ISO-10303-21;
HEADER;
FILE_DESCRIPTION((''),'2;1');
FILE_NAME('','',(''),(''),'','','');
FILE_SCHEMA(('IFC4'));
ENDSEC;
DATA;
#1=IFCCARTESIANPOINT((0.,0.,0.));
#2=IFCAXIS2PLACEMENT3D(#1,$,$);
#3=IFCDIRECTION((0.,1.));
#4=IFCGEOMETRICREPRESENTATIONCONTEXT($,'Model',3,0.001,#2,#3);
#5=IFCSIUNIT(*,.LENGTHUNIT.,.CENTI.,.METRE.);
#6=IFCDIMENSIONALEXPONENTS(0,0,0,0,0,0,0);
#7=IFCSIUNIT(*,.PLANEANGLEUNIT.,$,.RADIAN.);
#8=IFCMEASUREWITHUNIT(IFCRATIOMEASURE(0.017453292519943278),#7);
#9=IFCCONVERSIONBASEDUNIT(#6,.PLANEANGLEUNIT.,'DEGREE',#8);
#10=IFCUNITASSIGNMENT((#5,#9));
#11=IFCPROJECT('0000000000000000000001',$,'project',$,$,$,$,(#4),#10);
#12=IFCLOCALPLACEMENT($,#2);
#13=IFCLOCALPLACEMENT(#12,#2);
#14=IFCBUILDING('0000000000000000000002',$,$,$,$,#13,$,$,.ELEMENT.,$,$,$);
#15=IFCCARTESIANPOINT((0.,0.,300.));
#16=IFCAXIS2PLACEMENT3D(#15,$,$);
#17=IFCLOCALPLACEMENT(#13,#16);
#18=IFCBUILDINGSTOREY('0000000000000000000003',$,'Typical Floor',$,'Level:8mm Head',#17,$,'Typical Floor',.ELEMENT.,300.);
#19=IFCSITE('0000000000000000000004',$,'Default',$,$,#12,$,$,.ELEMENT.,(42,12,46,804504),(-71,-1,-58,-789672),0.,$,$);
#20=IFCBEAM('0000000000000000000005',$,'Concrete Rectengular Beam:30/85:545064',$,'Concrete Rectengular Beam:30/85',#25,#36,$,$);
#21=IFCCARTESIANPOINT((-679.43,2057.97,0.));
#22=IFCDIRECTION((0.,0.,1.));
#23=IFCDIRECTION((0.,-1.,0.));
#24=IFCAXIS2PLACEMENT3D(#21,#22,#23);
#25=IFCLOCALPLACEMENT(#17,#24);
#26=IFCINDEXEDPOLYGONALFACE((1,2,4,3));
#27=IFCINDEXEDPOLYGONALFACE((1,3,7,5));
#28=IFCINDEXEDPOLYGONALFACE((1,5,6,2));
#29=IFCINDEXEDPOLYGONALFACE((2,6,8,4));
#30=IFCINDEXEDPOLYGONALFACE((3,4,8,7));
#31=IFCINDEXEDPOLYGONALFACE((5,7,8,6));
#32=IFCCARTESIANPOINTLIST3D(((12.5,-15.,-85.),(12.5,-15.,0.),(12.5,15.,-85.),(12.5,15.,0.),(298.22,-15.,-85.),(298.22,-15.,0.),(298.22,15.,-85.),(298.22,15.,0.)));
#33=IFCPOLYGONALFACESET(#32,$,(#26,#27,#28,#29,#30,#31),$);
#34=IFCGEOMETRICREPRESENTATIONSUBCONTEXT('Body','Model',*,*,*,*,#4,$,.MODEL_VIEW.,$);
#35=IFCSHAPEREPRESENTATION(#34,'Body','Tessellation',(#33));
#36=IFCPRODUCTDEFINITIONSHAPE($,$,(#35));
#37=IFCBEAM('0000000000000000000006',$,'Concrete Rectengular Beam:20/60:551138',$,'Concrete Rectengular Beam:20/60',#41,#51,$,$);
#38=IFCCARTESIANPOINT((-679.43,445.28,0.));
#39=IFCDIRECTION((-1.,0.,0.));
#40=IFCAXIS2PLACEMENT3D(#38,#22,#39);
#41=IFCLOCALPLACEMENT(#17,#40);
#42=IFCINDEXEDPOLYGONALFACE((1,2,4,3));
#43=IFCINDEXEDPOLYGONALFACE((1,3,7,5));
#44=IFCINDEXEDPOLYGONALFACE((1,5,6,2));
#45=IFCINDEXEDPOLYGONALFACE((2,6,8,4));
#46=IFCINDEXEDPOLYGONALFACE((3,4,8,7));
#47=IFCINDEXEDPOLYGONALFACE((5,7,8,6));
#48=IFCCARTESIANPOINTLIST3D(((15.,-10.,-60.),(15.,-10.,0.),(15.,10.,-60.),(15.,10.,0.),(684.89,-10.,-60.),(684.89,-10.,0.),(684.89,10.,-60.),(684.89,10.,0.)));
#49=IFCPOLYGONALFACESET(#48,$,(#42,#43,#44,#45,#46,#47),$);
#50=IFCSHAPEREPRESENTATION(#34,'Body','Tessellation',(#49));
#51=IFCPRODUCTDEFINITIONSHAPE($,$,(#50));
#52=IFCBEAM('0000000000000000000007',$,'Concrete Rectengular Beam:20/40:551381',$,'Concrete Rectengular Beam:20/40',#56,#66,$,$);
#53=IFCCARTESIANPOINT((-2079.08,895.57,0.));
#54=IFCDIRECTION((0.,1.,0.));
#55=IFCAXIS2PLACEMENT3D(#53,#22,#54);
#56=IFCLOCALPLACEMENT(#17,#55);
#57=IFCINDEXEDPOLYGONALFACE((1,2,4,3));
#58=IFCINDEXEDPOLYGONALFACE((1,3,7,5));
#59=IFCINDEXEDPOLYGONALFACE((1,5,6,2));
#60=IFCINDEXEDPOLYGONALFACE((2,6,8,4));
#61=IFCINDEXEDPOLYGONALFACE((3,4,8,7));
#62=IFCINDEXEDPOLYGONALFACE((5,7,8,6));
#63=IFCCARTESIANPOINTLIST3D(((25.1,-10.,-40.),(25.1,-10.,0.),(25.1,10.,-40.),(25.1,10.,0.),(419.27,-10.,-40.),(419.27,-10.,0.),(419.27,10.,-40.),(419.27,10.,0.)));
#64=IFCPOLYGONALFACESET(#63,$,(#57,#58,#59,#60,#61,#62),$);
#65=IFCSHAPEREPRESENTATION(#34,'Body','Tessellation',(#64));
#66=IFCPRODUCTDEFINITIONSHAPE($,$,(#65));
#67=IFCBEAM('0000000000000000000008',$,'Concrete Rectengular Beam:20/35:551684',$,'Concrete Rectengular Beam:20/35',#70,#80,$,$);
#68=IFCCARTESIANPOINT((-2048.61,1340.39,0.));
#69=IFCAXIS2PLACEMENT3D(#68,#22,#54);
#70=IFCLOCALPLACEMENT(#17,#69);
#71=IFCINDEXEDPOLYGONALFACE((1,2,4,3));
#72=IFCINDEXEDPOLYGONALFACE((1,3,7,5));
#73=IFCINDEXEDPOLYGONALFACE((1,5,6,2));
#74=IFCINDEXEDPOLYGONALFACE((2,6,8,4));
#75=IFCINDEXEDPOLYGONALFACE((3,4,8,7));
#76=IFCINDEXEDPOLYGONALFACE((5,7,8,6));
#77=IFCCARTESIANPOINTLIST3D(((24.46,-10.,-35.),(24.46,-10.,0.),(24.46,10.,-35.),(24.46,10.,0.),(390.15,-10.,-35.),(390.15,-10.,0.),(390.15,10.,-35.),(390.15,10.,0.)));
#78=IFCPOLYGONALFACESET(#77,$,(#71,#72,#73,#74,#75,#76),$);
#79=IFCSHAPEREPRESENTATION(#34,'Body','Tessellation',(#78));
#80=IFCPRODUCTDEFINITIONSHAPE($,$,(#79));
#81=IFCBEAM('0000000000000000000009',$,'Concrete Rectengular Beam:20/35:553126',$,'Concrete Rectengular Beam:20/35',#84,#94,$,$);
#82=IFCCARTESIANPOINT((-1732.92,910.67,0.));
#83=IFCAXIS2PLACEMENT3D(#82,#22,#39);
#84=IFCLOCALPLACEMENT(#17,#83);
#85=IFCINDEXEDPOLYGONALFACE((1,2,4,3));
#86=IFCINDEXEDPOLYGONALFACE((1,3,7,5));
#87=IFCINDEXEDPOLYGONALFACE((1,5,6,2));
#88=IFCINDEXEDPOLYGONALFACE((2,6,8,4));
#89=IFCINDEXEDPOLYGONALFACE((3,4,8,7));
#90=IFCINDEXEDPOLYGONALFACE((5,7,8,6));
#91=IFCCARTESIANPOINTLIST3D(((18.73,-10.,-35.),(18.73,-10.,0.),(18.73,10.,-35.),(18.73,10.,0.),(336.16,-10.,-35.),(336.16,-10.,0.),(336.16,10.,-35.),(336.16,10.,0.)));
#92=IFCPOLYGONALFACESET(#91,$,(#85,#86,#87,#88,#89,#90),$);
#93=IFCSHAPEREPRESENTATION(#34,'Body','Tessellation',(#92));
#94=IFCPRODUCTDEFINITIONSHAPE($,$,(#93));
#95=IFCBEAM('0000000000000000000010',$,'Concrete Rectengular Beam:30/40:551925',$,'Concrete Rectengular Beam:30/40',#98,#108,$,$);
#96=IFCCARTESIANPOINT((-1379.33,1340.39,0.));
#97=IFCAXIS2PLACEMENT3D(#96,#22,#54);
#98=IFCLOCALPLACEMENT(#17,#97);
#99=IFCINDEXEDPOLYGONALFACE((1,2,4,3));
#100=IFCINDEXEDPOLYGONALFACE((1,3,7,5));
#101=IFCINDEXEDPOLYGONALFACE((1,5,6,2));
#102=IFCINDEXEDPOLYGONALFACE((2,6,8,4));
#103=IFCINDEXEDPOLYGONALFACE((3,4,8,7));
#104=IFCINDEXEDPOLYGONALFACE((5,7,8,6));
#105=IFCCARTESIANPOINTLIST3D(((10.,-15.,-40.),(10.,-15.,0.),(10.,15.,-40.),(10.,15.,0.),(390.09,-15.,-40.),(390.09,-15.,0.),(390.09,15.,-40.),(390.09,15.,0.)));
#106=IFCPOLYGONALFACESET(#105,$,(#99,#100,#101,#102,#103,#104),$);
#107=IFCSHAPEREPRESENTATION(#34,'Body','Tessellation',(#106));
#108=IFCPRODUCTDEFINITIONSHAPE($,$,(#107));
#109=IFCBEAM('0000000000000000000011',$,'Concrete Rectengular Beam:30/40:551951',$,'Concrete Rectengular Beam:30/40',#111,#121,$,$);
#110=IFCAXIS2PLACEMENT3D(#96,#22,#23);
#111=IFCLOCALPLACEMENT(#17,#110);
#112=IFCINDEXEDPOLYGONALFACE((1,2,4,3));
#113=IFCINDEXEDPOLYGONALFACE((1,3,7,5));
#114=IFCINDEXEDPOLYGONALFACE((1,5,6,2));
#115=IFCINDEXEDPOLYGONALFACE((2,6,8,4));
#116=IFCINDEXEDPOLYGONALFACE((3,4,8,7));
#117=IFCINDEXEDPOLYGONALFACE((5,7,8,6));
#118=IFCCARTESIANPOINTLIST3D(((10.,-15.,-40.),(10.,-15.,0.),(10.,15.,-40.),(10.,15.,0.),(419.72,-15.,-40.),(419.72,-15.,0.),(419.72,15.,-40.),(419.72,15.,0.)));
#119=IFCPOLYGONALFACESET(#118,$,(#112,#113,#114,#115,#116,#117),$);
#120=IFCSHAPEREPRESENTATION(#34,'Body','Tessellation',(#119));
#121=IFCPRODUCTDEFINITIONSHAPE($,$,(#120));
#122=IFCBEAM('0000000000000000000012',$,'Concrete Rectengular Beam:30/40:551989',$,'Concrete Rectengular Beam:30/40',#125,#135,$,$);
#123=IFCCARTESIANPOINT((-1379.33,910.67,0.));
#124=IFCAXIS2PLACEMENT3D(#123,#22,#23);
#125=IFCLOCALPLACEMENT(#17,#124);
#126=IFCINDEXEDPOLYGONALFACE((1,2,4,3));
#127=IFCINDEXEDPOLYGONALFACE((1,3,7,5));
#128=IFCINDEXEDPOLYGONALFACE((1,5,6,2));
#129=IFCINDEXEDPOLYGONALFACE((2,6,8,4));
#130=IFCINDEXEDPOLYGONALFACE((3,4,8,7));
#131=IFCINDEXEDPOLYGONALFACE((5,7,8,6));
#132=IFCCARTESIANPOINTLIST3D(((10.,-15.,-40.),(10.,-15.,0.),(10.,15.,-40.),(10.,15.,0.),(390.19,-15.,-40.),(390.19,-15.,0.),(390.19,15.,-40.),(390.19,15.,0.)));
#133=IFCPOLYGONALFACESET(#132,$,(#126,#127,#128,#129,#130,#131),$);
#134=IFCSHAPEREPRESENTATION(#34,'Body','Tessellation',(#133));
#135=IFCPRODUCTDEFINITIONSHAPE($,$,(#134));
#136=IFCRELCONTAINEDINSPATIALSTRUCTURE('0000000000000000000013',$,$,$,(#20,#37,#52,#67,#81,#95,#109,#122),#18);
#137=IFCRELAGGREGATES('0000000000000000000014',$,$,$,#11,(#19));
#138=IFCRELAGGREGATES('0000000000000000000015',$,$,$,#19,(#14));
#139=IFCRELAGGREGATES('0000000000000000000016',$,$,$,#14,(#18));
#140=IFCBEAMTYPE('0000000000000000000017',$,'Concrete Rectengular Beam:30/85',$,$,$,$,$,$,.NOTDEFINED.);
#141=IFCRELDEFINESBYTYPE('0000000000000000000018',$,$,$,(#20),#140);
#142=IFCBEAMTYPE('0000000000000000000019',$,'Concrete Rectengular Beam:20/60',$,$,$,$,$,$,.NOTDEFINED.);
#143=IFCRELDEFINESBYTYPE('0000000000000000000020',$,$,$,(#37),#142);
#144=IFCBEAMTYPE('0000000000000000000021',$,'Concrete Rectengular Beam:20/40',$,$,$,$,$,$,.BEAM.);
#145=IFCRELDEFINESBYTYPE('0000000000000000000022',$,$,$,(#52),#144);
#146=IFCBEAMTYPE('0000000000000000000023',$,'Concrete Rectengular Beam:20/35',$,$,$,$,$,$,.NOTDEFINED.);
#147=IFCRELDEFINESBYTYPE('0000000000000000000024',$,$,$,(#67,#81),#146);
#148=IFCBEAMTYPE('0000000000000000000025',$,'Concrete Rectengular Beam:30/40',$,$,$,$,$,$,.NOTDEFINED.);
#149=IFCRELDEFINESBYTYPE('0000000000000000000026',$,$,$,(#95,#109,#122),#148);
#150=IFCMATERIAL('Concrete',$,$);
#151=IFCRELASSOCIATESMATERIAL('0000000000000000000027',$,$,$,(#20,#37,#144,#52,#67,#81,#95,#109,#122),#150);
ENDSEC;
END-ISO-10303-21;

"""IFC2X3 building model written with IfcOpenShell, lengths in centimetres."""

from ifc_helpers import new_model, entity, si_unit, converted_unit, direction, frame, frame_2d, origin, place, context, subcontext, project, spatial, rectangle, extrude, material, type_object, element, save


model = new_model("IFC2X3")

# Units and contexts
model_context = context("Model", 3, precision=0.001, world=origin(), true_north=direction((0.0, 1.0)))
body_context = subcontext(model_context, "Body", "Model", "MODEL_VIEW")
ifc_project = project(units=[si_unit("LENGTHUNIT", "METRE", prefix="CENTI"), converted_unit("PLANEANGLEUNIT", "DEGREE", entity("IfcRatioMeasure", 0.017453292519943278), si_unit("PLANEANGLEUNIT", "RADIAN"), dimensions=[0, 0, 0, 0, 0, 0, 0])], contexts=[model_context])

# Site, building, storey
site_placement = place(None, origin())
site = spatial("IfcSite", under=ifc_project, at=site_placement, Name="Default", CompositionType="ELEMENT", RefLatitude=(42, 12, 46, 804504), RefLongitude=(-71, -1, -58, -789672), RefElevation=0.0)
building_placement = place(site_placement, origin())
building = spatial("IfcBuilding", under=site, at=building_placement, CompositionType="ELEMENT")
storey_placement = place(building_placement, frame((0.0, 0.0, 300.0)))
storey = spatial("IfcBuildingStorey", under=building, at=storey_placement, Name="Typical Floor", ObjectType="Level:8mm Head", LongName="Typical Floor", CompositionType="ELEMENT", Elevation=300.0)

# Beams
ifc_material = material(Name="Concrete")
beam_type_1 = type_object("IfcBeamType", Name="Concrete Rectengular Beam:30/85", PredefinedType="NOTDEFINED")
beam_1_placement = place(storey_placement, frame((-679.43, 2057.97, 0.0), z_axis=(0.0, 0.0, 1.0), x_axis=(0.0, -1.0, 0.0)))
element("IfcBeam", 1, at=beam_1_placement, inside=storey, type_object=beam_type_1, material=ifc_material, Name="Concrete Rectengular Beam:30/85:545064", ObjectType="Concrete Rectengular Beam:30/85", context=body_context, shape_type="SweptSolid", body=[
    extrude(rectangle(XDim=85.0, YDim=30.0, at=frame_2d((0.0, 0.0), x_axis=(1.0, 0.0))), frame((12.5, 0.0, -42.5), z_axis=(1.0, 0.0, 0.0), x_axis=(0.0, 0.0, -1.0)), (0.0, 0.0, 1.0), 285.72),
])
beam_type_2 = type_object("IfcBeamType", Name="Concrete Rectengular Beam:20/60", PredefinedType="NOTDEFINED")
beam_2_placement = place(storey_placement, frame((-679.43, 445.28, 0.0), z_axis=(0.0, 0.0, 1.0), x_axis=(-1.0, 0.0, 0.0)))
element("IfcBeam", 2, at=beam_2_placement, inside=storey, type_object=beam_type_2, material=ifc_material, Name="Concrete Rectengular Beam:20/60:551138", ObjectType="Concrete Rectengular Beam:20/60", context=body_context, shape_type="SweptSolid", body=[
    extrude(rectangle(XDim=60.0, YDim=20.0, at=frame_2d((0.0, 0.0), x_axis=(1.0, 0.0))), frame((15.0, 0.0, -30.0), z_axis=(1.0, 0.0, 0.0), x_axis=(0.0, 0.0, -1.0)), (0.0, 0.0, 1.0), 669.89),
])
beam_type_3 = type_object("IfcBeamType", Name="Concrete Rectengular Beam:20/40", PredefinedType="BEAM", material=ifc_material)
beam_3_placement = place(storey_placement, frame((-2079.08, 895.57, 0.0), z_axis=(0.0, 0.0, 1.0), x_axis=(0.0, 1.0, 0.0)))
element("IfcBeam", 3, at=beam_3_placement, inside=storey, type_object=beam_type_3, material=ifc_material, Name="Concrete Rectengular Beam:20/40:551381", ObjectType="Concrete Rectengular Beam:20/40", context=body_context, shape_type="SweptSolid", body=[
    extrude(rectangle(XDim=40.0, YDim=20.0, at=frame_2d((0.0, 0.0), x_axis=(1.0, 0.0))), frame((25.1, 0.0, -20.0), z_axis=(1.0, 0.0, 0.0), x_axis=(0.0, 0.0, -1.0)), (0.0, 0.0, 1.0), 394.17),
])
beam_type_4 = type_object("IfcBeamType", Name="Concrete Rectengular Beam:20/35", PredefinedType="NOTDEFINED")
beam_4_placement = place(storey_placement, frame((-2048.61, 1340.39, 0.0), z_axis=(0.0, 0.0, 1.0), x_axis=(0.0, 1.0, 0.0)))
element("IfcBeam", 4, at=beam_4_placement, inside=storey, type_object=beam_type_4, material=ifc_material, Name="Concrete Rectengular Beam:20/35:551684", ObjectType="Concrete Rectengular Beam:20/35", context=body_context, shape_type="SweptSolid", body=[
    extrude(rectangle(XDim=35.0, YDim=20.0, at=frame_2d((0.0, 0.0), x_axis=(1.0, 0.0))), frame((24.46, 0.0, -17.5), z_axis=(1.0, 0.0, 0.0), x_axis=(0.0, 0.0, -1.0)), (0.0, 0.0, 1.0), 365.69),
])
beam_5_placement = place(storey_placement, frame((-1732.92, 910.67, 0.0), z_axis=(0.0, 0.0, 1.0), x_axis=(-1.0, 0.0, 0.0)))
element("IfcBeam", 5, at=beam_5_placement, inside=storey, type_object=beam_type_4, material=ifc_material, Name="Concrete Rectengular Beam:20/35:553126", ObjectType="Concrete Rectengular Beam:20/35", context=body_context, shape_type="SweptSolid", body=[
    extrude(rectangle(XDim=35.0, YDim=20.0, at=frame_2d((0.0, 0.0), x_axis=(1.0, 0.0))), frame((18.73, 0.0, -17.5), z_axis=(1.0, 0.0, 0.0), x_axis=(0.0, 0.0, -1.0)), (0.0, 0.0, 1.0), 317.43),
])
beam_type_5 = type_object("IfcBeamType", Name="Concrete Rectengular Beam:30/40", PredefinedType="NOTDEFINED")
beam_6_placement = place(storey_placement, frame((-1379.33, 1340.39, 0.0), z_axis=(0.0, 0.0, 1.0), x_axis=(0.0, 1.0, 0.0)))
element("IfcBeam", 6, at=beam_6_placement, inside=storey, type_object=beam_type_5, material=ifc_material, Name="Concrete Rectengular Beam:30/40:551925", ObjectType="Concrete Rectengular Beam:30/40", context=body_context, shape_type="SweptSolid", body=[
    extrude(rectangle(XDim=40.0, YDim=30.0, at=frame_2d((0.0, 0.0), x_axis=(1.0, 0.0))), frame((10.0, 0.0, -20.0), z_axis=(1.0, 0.0, 0.0), x_axis=(0.0, 0.0, -1.0)), (0.0, 0.0, 1.0), 380.09),
])
beam_7_placement = place(storey_placement, frame((-1379.33, 1340.39, 0.0), z_axis=(0.0, 0.0, 1.0), x_axis=(0.0, -1.0, 0.0)))
element("IfcBeam", 7, at=beam_7_placement, inside=storey, type_object=beam_type_5, material=ifc_material, Name="Concrete Rectengular Beam:30/40:551951", ObjectType="Concrete Rectengular Beam:30/40", context=body_context, shape_type="SweptSolid", body=[
    extrude(rectangle(XDim=40.0, YDim=30.0, at=frame_2d((0.0, 0.0), x_axis=(1.0, 0.0))), frame((10.0, 0.0, -20.0), z_axis=(1.0, 0.0, 0.0), x_axis=(0.0, 0.0, -1.0)), (0.0, 0.0, 1.0), 409.72),
])
beam_8_placement = place(storey_placement, frame((-1379.33, 910.67, 0.0), z_axis=(0.0, 0.0, 1.0), x_axis=(0.0, -1.0, 0.0)))
element("IfcBeam", 8, at=beam_8_placement, inside=storey, type_object=beam_type_5, material=ifc_material, Name="Concrete Rectengular Beam:30/40:551989", ObjectType="Concrete Rectengular Beam:30/40", context=body_context, shape_type="SweptSolid", body=[
    extrude(rectangle(XDim=40.0, YDim=30.0, at=frame_2d((0.0, 0.0), x_axis=(1.0, 0.0))), frame((10.0, 0.0, -20.0), z_axis=(1.0, 0.0, 0.0), x_axis=(0.0, 0.0, -1.0)), (0.0, 0.0, 1.0), 380.19),
])

save(model, "model.ifc")
